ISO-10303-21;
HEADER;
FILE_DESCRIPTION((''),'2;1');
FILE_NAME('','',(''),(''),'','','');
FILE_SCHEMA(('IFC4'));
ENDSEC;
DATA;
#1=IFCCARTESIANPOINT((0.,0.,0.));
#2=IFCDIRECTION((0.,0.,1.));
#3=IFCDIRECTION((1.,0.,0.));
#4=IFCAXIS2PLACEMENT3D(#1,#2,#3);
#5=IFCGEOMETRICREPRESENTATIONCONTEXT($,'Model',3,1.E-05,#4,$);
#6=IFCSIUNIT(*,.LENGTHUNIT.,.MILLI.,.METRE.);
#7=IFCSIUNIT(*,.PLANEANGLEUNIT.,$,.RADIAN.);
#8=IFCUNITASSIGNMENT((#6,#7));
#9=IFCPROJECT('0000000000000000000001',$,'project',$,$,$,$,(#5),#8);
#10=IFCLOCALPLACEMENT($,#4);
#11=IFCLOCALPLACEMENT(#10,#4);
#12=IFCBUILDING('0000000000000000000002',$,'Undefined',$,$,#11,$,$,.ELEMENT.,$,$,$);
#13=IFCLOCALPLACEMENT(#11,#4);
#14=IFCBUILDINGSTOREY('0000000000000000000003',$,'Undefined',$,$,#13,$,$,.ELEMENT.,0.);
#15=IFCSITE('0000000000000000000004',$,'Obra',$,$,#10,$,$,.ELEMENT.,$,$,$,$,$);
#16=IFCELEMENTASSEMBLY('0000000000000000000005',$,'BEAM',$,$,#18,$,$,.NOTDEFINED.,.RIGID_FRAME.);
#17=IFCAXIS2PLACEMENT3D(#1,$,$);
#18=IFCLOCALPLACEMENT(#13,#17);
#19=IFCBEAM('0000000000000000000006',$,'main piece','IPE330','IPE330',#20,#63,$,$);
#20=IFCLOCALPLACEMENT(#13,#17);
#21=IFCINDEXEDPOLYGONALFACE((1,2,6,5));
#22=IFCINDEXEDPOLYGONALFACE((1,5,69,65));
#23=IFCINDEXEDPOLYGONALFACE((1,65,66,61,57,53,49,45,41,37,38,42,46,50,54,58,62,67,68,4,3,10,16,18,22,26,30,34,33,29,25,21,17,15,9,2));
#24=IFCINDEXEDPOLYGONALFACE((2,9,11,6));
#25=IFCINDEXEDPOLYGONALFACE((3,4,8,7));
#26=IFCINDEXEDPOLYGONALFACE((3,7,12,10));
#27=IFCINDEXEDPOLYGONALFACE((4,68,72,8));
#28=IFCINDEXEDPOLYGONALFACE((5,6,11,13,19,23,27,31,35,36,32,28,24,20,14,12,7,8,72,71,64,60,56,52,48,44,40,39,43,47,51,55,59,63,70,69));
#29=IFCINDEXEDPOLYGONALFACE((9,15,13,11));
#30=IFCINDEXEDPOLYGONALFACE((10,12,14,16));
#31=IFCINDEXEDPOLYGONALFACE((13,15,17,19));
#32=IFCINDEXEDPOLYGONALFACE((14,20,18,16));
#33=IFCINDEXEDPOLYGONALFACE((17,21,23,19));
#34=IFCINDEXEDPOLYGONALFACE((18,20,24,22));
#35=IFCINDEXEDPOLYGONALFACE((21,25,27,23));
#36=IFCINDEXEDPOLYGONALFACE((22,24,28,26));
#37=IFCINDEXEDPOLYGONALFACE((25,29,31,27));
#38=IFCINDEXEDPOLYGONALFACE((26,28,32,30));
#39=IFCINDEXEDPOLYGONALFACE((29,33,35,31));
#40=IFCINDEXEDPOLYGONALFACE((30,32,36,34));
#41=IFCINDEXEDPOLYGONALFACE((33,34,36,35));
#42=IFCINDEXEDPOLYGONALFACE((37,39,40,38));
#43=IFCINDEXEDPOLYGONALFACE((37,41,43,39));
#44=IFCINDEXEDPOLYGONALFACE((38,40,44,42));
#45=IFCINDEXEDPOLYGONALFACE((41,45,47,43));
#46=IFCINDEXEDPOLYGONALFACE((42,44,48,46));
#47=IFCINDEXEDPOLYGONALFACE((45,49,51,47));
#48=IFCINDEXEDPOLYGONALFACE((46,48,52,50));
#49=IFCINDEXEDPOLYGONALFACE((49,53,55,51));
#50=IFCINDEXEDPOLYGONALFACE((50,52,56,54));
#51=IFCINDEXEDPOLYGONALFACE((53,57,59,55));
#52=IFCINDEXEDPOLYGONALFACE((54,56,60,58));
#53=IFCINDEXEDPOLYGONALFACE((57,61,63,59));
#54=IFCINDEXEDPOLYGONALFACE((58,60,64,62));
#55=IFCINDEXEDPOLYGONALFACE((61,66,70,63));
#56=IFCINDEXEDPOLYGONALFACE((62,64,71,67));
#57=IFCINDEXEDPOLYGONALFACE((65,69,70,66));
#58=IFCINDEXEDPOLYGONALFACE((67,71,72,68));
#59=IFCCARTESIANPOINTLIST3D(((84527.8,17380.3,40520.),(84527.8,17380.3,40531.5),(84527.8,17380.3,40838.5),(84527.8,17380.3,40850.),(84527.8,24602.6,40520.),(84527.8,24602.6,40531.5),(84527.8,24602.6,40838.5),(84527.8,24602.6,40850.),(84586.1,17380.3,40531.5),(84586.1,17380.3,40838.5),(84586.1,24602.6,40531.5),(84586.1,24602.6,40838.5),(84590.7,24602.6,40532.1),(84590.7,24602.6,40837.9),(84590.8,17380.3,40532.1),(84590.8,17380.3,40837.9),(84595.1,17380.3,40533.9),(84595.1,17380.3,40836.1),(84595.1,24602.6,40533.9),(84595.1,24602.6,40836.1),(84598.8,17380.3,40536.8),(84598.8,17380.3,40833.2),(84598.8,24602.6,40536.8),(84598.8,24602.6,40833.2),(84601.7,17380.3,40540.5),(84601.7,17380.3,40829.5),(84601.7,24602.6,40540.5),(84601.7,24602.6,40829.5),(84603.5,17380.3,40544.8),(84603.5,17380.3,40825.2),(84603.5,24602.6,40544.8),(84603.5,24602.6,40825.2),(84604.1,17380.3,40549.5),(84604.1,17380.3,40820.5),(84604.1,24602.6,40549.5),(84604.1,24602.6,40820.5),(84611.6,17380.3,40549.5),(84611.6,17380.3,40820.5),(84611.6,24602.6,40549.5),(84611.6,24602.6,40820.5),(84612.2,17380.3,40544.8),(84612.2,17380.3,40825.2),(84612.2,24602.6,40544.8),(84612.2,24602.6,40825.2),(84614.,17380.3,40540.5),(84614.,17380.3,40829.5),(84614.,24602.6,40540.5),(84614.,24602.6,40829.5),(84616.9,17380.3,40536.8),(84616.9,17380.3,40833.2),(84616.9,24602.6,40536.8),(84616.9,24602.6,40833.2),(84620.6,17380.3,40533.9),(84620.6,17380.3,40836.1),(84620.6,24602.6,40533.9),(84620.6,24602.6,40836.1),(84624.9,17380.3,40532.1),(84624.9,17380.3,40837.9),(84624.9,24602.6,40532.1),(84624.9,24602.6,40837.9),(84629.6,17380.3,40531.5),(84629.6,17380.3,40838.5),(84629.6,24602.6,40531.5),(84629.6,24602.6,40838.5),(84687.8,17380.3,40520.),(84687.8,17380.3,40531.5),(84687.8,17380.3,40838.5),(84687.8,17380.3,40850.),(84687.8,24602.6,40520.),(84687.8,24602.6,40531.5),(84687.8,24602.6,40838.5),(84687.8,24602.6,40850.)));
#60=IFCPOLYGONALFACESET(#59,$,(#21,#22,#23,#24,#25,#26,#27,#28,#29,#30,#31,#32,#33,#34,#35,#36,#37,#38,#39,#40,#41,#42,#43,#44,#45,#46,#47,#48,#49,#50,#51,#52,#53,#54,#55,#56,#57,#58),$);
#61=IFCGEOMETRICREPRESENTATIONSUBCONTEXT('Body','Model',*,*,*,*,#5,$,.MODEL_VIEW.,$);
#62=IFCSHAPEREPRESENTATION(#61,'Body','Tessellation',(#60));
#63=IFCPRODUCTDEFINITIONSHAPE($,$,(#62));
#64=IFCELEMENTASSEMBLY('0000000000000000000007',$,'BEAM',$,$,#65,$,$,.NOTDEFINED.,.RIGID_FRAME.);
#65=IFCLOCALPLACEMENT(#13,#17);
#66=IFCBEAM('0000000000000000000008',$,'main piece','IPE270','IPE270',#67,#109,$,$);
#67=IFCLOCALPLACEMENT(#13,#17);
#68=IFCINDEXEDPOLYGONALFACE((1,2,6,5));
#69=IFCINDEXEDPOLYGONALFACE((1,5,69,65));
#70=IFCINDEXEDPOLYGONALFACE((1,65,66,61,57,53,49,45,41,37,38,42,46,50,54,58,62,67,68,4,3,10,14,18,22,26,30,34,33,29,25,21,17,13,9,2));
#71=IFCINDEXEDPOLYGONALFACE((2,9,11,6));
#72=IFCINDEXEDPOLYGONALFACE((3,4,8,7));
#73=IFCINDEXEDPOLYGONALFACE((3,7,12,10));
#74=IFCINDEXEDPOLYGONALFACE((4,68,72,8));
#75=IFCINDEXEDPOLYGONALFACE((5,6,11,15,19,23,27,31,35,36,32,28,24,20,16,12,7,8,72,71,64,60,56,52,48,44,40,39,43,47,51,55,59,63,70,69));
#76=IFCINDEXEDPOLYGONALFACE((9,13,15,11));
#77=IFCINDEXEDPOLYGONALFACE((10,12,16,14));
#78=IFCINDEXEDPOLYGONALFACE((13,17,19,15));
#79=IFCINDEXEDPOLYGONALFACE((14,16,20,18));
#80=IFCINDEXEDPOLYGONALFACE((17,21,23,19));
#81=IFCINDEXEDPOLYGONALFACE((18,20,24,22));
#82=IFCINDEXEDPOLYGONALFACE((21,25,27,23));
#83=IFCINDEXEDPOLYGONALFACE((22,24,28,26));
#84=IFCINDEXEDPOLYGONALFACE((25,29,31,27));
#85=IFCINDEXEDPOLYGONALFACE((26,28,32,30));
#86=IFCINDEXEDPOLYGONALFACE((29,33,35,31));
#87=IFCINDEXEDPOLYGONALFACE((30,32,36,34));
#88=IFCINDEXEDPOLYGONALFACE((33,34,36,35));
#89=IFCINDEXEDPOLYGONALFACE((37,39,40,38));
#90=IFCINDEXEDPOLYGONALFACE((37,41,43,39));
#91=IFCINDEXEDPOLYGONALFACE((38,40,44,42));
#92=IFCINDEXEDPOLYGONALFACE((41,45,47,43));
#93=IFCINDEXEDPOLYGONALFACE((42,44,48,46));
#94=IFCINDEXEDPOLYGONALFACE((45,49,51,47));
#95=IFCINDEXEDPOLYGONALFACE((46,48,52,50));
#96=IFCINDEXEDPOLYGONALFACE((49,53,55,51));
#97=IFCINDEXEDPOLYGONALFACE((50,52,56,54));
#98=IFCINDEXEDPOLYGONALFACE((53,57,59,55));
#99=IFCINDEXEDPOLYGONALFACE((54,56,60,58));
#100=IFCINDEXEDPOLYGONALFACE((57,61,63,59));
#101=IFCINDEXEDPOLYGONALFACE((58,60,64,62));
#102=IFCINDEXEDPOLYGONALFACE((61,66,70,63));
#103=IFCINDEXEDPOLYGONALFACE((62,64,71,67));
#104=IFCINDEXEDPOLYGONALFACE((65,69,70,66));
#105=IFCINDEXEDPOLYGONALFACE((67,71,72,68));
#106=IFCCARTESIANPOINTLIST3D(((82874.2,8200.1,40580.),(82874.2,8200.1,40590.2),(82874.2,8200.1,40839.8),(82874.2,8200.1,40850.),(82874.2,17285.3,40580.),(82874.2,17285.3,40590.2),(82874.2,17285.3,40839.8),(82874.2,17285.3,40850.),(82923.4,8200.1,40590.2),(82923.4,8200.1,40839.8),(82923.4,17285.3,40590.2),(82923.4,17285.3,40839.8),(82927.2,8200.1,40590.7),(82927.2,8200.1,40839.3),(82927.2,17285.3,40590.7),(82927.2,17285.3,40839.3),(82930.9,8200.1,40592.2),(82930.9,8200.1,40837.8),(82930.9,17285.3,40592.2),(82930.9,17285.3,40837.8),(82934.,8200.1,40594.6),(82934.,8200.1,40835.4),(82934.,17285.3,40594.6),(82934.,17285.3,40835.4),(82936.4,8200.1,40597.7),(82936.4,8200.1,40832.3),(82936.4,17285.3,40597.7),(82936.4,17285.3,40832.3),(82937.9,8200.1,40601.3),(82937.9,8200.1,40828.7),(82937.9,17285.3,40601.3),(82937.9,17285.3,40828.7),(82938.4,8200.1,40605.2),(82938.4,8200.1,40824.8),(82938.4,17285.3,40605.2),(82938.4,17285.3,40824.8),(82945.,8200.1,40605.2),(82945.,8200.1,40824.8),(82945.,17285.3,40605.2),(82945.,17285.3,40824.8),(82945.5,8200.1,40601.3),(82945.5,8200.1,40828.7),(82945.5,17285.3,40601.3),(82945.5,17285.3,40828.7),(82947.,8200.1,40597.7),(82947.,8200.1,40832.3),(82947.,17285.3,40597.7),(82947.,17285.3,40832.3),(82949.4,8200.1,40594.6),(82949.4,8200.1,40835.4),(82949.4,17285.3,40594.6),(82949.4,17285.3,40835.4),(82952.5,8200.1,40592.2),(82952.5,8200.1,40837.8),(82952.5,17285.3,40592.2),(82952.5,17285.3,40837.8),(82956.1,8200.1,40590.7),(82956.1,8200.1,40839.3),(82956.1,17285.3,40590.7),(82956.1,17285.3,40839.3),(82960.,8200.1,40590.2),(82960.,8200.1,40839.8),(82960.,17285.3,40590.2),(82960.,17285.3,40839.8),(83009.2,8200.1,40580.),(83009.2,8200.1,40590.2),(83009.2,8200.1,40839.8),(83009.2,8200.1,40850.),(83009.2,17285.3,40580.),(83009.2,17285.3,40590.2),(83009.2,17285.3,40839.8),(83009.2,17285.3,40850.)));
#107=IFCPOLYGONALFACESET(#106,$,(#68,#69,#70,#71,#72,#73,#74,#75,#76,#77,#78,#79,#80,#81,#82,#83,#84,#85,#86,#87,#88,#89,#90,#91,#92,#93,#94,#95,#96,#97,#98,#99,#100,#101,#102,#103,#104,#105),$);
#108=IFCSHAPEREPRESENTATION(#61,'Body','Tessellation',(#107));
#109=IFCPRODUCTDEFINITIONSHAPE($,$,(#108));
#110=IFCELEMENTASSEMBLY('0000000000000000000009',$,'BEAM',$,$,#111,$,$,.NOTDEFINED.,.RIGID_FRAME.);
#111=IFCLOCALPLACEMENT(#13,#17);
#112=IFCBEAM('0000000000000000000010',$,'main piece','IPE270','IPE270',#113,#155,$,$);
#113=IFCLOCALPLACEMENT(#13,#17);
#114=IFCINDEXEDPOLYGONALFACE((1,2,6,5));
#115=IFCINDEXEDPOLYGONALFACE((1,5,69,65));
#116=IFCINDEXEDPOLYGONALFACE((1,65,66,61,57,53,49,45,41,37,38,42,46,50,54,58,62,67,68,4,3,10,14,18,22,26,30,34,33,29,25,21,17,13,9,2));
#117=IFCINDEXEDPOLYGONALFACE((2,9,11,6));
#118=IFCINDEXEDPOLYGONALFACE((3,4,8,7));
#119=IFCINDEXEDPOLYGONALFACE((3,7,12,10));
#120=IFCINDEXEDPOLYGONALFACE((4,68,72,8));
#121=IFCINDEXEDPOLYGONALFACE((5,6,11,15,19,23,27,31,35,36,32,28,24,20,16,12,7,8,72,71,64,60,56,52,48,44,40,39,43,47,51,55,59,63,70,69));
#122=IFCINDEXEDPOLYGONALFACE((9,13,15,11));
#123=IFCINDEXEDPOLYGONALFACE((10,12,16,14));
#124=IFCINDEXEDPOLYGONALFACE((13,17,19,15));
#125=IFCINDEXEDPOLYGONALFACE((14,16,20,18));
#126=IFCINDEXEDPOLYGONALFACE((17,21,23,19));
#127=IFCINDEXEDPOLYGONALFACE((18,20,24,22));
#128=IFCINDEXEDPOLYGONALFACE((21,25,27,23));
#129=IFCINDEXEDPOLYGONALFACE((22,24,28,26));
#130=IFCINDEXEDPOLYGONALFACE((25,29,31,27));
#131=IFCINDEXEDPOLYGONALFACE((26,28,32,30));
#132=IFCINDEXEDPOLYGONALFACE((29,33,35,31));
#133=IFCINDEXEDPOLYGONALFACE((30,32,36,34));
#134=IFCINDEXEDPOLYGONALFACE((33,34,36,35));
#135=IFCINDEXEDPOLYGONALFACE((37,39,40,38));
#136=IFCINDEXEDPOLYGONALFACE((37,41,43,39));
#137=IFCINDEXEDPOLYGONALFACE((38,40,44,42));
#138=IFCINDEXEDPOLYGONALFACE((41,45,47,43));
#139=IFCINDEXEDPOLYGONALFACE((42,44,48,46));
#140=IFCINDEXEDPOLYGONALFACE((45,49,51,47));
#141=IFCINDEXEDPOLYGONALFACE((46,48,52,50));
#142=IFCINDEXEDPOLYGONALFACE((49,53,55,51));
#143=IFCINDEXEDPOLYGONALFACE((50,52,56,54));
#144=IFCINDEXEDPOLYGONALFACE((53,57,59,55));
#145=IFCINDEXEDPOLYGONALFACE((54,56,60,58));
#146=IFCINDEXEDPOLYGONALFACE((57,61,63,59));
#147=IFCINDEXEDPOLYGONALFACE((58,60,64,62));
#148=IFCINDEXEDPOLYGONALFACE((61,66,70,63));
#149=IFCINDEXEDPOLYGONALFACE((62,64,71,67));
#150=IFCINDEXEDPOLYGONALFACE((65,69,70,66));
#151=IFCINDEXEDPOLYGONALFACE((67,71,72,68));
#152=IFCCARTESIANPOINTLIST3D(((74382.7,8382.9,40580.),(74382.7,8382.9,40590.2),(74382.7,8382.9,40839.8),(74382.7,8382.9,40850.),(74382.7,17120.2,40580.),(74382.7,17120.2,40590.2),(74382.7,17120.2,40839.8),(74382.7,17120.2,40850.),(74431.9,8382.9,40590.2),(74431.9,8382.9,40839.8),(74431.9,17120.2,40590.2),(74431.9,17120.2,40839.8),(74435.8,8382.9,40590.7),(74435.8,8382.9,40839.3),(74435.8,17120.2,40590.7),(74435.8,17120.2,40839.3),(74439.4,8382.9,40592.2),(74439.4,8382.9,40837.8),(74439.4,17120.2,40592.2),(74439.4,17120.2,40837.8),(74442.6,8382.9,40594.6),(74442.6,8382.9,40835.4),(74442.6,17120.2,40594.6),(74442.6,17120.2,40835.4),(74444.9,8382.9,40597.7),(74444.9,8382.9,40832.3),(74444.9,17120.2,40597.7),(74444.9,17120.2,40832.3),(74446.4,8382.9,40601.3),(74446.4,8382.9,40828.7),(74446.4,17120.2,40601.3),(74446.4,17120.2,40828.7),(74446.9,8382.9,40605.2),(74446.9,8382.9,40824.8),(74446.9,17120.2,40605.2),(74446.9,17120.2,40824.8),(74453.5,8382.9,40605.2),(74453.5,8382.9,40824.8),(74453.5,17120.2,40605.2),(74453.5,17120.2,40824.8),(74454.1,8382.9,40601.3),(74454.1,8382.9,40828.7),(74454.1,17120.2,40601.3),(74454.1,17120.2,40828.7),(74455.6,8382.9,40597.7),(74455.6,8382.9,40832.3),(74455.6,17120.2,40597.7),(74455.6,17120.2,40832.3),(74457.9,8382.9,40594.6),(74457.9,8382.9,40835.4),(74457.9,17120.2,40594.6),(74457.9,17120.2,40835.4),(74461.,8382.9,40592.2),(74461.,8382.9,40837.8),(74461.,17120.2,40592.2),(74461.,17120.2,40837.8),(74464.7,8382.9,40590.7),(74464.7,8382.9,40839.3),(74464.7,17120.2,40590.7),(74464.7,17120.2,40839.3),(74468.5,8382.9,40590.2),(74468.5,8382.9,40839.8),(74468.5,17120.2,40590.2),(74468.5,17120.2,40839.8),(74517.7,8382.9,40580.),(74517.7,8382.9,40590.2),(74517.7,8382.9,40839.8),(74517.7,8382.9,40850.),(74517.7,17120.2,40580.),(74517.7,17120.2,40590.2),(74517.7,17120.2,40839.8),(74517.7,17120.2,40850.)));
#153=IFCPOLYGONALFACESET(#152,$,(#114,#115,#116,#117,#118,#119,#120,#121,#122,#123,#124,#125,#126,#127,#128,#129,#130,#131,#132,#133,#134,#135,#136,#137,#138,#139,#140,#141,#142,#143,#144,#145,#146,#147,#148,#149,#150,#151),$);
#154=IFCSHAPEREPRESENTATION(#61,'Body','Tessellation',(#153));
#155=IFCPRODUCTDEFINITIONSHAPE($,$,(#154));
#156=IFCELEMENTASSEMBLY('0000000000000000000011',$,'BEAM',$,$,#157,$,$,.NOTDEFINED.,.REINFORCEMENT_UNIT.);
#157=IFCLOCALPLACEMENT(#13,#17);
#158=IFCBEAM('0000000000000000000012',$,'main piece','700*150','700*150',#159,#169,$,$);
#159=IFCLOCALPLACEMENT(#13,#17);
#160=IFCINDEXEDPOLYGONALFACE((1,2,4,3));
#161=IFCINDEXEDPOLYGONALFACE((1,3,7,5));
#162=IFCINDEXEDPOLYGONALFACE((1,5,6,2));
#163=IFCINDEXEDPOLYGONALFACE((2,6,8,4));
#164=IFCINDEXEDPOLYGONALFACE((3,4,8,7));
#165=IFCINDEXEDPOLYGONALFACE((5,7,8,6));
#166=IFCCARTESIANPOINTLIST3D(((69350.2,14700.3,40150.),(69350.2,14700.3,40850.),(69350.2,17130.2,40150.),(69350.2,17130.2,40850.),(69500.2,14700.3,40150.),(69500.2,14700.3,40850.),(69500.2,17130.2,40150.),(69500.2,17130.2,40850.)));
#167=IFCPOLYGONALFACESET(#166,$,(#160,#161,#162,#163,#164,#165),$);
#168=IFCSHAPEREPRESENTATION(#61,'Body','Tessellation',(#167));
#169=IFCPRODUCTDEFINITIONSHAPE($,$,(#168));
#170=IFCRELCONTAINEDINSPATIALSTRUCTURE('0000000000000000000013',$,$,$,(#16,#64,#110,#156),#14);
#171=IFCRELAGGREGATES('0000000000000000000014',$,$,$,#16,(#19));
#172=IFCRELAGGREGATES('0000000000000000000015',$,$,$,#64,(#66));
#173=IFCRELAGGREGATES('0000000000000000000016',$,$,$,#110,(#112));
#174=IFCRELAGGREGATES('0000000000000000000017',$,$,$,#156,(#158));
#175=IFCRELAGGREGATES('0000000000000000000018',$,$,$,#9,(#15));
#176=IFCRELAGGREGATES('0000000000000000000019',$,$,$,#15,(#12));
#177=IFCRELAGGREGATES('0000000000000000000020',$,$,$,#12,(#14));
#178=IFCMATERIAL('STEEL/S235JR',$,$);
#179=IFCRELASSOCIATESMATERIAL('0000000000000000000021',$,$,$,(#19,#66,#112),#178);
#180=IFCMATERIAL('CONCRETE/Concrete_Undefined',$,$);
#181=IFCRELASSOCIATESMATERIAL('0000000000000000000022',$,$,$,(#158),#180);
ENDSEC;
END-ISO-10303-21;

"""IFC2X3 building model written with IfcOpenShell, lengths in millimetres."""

from ifc_helpers import new_model, si_unit, frame, origin_with_axes, origin_2d_with_axis, place, context, subcontext, project, spatial, rectangle, i_section, extrude, material, element, aggregate, save


model = new_model("IFC2X3")

# Units and contexts
model_context = context("Model", 3, precision=1e-05, world=origin_with_axes())
body_context = subcontext(model_context, "Body", "Model", "MODEL_VIEW")
ifc_project = project(units=[si_unit("LENGTHUNIT", "METRE", prefix="MILLI"), si_unit("PLANEANGLEUNIT", "RADIAN")], contexts=[model_context])

# Site, building, storey
site_placement = place(None, origin_with_axes())
site = spatial("IfcSite", under=ifc_project, at=site_placement, Name="Obra", CompositionType="ELEMENT")
building_placement = place(site_placement, origin_with_axes())
building = spatial("IfcBuilding", under=site, at=building_placement, Name="Undefined", CompositionType="ELEMENT")
storey_placement = place(building_placement, origin_with_axes())
storey = spatial("IfcBuildingStorey", under=building, at=storey_placement, Name="Undefined", CompositionType="ELEMENT", Elevation=0.0)

# Element assemblies, beams
ifc_material_1 = material(Name="CONCRETE/Concrete_Undefined")
ifc_material_2 = material(Name="STEEL/S235JR")
assembly_1_placement = place(storey_placement, origin_with_axes())
assembly_1 = element("IfcElementAssembly", 1, at=assembly_1_placement, inside=storey, Name="BEAM", AssemblyPlace="NOTDEFINED", PredefinedType="RIGID_FRAME")
beam_1_placement = place(assembly_1_placement, frame((84607.8, 17380.3, 40685.0), z_axis=(0.0, 0.0, 1.0), x_axis=(-0.000001, 1.0, 0.0)))
beam_1 = element("IfcBeam", 2, at=beam_1_placement, material=ifc_material_2, Name="main piece", Description="IPE330", ObjectType="IPE330", context=body_context, shape_type="SweptSolid", body=[
    extrude(i_section(OverallWidth=160.0, OverallDepth=330.0, WebThickness=7.5, FlangeThickness=11.5, FilletRadius=18.0, at=origin_2d_with_axis()), frame((7222.3, 0.0, 0.0), z_axis=(-1.0, 0.0, 0.0), x_axis=(0.0, -1.0, 0.0)), (0.0, 0.0, 1.0), 7222.3),
])
aggregate(assembly_1, [beam_1])
assembly_2_placement = place(storey_placement, origin_with_axes())
assembly_2 = element("IfcElementAssembly", 3, at=assembly_2_placement, inside=storey, Name="BEAM", AssemblyPlace="NOTDEFINED", PredefinedType="RIGID_FRAME")
beam_2_placement = place(assembly_2_placement, frame((82941.7, 17285.3, 40715.0), z_axis=(0.0, 0.0, 1.0), x_axis=(0.0, -1.0, 0.0)))
beam_2 = element("IfcBeam", 4, at=beam_2_placement, material=ifc_material_2, Name="main piece", Description="IPE270", ObjectType="IPE270", context=body_context, shape_type="SweptSolid", body=[
    extrude(i_section(OverallWidth=135.0, OverallDepth=270.0, WebThickness=6.6, FlangeThickness=10.2, FilletRadius=15.0, at=origin_2d_with_axis()), frame((9085.2, 0.0, 0.0), z_axis=(-1.0, 0.0, 0.0), x_axis=(0.0, -1.0, 0.0)), (0.0, 0.0, 1.0), 9085.2),
])
aggregate(assembly_2, [beam_2])
assembly_3_placement = place(storey_placement, origin_with_axes())
assembly_3 = element("IfcElementAssembly", 5, at=assembly_3_placement, inside=storey, Name="BEAM", AssemblyPlace="NOTDEFINED", PredefinedType="RIGID_FRAME")
beam_3_placement = place(assembly_3_placement, frame((74450.2, 8382.9, 40715.0), z_axis=(0.0, 0.0, 1.0), x_axis=(0.0, 1.0, 0.0)))
beam_3 = element("IfcBeam", 6, at=beam_3_placement, material=ifc_material_2, Name="main piece", Description="IPE270", ObjectType="IPE270", context=body_context, shape_type="SweptSolid", body=[
    extrude(i_section(OverallWidth=135.0, OverallDepth=270.0, WebThickness=6.6, FlangeThickness=10.2, FilletRadius=15.0, at=origin_2d_with_axis()), frame((8737.3, 0.0, 0.0), z_axis=(-1.0, 0.0, 0.0), x_axis=(0.0, -1.0, 0.0)), (0.0, 0.0, 1.0), 8737.3),
])
aggregate(assembly_3, [beam_3])
assembly_4_placement = place(storey_placement, origin_with_axes())
assembly_4 = element("IfcElementAssembly", 7, at=assembly_4_placement, inside=storey, Name="BEAM", AssemblyPlace="NOTDEFINED", PredefinedType="REINFORCEMENT_UNIT")
beam_4_placement = place(assembly_4_placement, frame((69425.2, 14700.3, 40500.0), z_axis=(0.0, 0.0, 1.0), x_axis=(0.0, 1.0, 0.0)))
beam_4 = element("IfcBeam", 8, at=beam_4_placement, material=ifc_material_1, Name="main piece", Description="700*150", ObjectType="700*150", context=body_context, shape_type="SweptSolid", body=[
    extrude(rectangle(XDim=150.0, YDim=700.0, at=origin_2d_with_axis()), frame((2429.9, 0.0, 0.0), z_axis=(-1.0, 0.0, 0.0), x_axis=(0.0, -1.0, 0.0)), (0.0, 0.0, 1.0), 2429.9),
])
aggregate(assembly_4, [beam_4])

save(model, "model.ifc")
